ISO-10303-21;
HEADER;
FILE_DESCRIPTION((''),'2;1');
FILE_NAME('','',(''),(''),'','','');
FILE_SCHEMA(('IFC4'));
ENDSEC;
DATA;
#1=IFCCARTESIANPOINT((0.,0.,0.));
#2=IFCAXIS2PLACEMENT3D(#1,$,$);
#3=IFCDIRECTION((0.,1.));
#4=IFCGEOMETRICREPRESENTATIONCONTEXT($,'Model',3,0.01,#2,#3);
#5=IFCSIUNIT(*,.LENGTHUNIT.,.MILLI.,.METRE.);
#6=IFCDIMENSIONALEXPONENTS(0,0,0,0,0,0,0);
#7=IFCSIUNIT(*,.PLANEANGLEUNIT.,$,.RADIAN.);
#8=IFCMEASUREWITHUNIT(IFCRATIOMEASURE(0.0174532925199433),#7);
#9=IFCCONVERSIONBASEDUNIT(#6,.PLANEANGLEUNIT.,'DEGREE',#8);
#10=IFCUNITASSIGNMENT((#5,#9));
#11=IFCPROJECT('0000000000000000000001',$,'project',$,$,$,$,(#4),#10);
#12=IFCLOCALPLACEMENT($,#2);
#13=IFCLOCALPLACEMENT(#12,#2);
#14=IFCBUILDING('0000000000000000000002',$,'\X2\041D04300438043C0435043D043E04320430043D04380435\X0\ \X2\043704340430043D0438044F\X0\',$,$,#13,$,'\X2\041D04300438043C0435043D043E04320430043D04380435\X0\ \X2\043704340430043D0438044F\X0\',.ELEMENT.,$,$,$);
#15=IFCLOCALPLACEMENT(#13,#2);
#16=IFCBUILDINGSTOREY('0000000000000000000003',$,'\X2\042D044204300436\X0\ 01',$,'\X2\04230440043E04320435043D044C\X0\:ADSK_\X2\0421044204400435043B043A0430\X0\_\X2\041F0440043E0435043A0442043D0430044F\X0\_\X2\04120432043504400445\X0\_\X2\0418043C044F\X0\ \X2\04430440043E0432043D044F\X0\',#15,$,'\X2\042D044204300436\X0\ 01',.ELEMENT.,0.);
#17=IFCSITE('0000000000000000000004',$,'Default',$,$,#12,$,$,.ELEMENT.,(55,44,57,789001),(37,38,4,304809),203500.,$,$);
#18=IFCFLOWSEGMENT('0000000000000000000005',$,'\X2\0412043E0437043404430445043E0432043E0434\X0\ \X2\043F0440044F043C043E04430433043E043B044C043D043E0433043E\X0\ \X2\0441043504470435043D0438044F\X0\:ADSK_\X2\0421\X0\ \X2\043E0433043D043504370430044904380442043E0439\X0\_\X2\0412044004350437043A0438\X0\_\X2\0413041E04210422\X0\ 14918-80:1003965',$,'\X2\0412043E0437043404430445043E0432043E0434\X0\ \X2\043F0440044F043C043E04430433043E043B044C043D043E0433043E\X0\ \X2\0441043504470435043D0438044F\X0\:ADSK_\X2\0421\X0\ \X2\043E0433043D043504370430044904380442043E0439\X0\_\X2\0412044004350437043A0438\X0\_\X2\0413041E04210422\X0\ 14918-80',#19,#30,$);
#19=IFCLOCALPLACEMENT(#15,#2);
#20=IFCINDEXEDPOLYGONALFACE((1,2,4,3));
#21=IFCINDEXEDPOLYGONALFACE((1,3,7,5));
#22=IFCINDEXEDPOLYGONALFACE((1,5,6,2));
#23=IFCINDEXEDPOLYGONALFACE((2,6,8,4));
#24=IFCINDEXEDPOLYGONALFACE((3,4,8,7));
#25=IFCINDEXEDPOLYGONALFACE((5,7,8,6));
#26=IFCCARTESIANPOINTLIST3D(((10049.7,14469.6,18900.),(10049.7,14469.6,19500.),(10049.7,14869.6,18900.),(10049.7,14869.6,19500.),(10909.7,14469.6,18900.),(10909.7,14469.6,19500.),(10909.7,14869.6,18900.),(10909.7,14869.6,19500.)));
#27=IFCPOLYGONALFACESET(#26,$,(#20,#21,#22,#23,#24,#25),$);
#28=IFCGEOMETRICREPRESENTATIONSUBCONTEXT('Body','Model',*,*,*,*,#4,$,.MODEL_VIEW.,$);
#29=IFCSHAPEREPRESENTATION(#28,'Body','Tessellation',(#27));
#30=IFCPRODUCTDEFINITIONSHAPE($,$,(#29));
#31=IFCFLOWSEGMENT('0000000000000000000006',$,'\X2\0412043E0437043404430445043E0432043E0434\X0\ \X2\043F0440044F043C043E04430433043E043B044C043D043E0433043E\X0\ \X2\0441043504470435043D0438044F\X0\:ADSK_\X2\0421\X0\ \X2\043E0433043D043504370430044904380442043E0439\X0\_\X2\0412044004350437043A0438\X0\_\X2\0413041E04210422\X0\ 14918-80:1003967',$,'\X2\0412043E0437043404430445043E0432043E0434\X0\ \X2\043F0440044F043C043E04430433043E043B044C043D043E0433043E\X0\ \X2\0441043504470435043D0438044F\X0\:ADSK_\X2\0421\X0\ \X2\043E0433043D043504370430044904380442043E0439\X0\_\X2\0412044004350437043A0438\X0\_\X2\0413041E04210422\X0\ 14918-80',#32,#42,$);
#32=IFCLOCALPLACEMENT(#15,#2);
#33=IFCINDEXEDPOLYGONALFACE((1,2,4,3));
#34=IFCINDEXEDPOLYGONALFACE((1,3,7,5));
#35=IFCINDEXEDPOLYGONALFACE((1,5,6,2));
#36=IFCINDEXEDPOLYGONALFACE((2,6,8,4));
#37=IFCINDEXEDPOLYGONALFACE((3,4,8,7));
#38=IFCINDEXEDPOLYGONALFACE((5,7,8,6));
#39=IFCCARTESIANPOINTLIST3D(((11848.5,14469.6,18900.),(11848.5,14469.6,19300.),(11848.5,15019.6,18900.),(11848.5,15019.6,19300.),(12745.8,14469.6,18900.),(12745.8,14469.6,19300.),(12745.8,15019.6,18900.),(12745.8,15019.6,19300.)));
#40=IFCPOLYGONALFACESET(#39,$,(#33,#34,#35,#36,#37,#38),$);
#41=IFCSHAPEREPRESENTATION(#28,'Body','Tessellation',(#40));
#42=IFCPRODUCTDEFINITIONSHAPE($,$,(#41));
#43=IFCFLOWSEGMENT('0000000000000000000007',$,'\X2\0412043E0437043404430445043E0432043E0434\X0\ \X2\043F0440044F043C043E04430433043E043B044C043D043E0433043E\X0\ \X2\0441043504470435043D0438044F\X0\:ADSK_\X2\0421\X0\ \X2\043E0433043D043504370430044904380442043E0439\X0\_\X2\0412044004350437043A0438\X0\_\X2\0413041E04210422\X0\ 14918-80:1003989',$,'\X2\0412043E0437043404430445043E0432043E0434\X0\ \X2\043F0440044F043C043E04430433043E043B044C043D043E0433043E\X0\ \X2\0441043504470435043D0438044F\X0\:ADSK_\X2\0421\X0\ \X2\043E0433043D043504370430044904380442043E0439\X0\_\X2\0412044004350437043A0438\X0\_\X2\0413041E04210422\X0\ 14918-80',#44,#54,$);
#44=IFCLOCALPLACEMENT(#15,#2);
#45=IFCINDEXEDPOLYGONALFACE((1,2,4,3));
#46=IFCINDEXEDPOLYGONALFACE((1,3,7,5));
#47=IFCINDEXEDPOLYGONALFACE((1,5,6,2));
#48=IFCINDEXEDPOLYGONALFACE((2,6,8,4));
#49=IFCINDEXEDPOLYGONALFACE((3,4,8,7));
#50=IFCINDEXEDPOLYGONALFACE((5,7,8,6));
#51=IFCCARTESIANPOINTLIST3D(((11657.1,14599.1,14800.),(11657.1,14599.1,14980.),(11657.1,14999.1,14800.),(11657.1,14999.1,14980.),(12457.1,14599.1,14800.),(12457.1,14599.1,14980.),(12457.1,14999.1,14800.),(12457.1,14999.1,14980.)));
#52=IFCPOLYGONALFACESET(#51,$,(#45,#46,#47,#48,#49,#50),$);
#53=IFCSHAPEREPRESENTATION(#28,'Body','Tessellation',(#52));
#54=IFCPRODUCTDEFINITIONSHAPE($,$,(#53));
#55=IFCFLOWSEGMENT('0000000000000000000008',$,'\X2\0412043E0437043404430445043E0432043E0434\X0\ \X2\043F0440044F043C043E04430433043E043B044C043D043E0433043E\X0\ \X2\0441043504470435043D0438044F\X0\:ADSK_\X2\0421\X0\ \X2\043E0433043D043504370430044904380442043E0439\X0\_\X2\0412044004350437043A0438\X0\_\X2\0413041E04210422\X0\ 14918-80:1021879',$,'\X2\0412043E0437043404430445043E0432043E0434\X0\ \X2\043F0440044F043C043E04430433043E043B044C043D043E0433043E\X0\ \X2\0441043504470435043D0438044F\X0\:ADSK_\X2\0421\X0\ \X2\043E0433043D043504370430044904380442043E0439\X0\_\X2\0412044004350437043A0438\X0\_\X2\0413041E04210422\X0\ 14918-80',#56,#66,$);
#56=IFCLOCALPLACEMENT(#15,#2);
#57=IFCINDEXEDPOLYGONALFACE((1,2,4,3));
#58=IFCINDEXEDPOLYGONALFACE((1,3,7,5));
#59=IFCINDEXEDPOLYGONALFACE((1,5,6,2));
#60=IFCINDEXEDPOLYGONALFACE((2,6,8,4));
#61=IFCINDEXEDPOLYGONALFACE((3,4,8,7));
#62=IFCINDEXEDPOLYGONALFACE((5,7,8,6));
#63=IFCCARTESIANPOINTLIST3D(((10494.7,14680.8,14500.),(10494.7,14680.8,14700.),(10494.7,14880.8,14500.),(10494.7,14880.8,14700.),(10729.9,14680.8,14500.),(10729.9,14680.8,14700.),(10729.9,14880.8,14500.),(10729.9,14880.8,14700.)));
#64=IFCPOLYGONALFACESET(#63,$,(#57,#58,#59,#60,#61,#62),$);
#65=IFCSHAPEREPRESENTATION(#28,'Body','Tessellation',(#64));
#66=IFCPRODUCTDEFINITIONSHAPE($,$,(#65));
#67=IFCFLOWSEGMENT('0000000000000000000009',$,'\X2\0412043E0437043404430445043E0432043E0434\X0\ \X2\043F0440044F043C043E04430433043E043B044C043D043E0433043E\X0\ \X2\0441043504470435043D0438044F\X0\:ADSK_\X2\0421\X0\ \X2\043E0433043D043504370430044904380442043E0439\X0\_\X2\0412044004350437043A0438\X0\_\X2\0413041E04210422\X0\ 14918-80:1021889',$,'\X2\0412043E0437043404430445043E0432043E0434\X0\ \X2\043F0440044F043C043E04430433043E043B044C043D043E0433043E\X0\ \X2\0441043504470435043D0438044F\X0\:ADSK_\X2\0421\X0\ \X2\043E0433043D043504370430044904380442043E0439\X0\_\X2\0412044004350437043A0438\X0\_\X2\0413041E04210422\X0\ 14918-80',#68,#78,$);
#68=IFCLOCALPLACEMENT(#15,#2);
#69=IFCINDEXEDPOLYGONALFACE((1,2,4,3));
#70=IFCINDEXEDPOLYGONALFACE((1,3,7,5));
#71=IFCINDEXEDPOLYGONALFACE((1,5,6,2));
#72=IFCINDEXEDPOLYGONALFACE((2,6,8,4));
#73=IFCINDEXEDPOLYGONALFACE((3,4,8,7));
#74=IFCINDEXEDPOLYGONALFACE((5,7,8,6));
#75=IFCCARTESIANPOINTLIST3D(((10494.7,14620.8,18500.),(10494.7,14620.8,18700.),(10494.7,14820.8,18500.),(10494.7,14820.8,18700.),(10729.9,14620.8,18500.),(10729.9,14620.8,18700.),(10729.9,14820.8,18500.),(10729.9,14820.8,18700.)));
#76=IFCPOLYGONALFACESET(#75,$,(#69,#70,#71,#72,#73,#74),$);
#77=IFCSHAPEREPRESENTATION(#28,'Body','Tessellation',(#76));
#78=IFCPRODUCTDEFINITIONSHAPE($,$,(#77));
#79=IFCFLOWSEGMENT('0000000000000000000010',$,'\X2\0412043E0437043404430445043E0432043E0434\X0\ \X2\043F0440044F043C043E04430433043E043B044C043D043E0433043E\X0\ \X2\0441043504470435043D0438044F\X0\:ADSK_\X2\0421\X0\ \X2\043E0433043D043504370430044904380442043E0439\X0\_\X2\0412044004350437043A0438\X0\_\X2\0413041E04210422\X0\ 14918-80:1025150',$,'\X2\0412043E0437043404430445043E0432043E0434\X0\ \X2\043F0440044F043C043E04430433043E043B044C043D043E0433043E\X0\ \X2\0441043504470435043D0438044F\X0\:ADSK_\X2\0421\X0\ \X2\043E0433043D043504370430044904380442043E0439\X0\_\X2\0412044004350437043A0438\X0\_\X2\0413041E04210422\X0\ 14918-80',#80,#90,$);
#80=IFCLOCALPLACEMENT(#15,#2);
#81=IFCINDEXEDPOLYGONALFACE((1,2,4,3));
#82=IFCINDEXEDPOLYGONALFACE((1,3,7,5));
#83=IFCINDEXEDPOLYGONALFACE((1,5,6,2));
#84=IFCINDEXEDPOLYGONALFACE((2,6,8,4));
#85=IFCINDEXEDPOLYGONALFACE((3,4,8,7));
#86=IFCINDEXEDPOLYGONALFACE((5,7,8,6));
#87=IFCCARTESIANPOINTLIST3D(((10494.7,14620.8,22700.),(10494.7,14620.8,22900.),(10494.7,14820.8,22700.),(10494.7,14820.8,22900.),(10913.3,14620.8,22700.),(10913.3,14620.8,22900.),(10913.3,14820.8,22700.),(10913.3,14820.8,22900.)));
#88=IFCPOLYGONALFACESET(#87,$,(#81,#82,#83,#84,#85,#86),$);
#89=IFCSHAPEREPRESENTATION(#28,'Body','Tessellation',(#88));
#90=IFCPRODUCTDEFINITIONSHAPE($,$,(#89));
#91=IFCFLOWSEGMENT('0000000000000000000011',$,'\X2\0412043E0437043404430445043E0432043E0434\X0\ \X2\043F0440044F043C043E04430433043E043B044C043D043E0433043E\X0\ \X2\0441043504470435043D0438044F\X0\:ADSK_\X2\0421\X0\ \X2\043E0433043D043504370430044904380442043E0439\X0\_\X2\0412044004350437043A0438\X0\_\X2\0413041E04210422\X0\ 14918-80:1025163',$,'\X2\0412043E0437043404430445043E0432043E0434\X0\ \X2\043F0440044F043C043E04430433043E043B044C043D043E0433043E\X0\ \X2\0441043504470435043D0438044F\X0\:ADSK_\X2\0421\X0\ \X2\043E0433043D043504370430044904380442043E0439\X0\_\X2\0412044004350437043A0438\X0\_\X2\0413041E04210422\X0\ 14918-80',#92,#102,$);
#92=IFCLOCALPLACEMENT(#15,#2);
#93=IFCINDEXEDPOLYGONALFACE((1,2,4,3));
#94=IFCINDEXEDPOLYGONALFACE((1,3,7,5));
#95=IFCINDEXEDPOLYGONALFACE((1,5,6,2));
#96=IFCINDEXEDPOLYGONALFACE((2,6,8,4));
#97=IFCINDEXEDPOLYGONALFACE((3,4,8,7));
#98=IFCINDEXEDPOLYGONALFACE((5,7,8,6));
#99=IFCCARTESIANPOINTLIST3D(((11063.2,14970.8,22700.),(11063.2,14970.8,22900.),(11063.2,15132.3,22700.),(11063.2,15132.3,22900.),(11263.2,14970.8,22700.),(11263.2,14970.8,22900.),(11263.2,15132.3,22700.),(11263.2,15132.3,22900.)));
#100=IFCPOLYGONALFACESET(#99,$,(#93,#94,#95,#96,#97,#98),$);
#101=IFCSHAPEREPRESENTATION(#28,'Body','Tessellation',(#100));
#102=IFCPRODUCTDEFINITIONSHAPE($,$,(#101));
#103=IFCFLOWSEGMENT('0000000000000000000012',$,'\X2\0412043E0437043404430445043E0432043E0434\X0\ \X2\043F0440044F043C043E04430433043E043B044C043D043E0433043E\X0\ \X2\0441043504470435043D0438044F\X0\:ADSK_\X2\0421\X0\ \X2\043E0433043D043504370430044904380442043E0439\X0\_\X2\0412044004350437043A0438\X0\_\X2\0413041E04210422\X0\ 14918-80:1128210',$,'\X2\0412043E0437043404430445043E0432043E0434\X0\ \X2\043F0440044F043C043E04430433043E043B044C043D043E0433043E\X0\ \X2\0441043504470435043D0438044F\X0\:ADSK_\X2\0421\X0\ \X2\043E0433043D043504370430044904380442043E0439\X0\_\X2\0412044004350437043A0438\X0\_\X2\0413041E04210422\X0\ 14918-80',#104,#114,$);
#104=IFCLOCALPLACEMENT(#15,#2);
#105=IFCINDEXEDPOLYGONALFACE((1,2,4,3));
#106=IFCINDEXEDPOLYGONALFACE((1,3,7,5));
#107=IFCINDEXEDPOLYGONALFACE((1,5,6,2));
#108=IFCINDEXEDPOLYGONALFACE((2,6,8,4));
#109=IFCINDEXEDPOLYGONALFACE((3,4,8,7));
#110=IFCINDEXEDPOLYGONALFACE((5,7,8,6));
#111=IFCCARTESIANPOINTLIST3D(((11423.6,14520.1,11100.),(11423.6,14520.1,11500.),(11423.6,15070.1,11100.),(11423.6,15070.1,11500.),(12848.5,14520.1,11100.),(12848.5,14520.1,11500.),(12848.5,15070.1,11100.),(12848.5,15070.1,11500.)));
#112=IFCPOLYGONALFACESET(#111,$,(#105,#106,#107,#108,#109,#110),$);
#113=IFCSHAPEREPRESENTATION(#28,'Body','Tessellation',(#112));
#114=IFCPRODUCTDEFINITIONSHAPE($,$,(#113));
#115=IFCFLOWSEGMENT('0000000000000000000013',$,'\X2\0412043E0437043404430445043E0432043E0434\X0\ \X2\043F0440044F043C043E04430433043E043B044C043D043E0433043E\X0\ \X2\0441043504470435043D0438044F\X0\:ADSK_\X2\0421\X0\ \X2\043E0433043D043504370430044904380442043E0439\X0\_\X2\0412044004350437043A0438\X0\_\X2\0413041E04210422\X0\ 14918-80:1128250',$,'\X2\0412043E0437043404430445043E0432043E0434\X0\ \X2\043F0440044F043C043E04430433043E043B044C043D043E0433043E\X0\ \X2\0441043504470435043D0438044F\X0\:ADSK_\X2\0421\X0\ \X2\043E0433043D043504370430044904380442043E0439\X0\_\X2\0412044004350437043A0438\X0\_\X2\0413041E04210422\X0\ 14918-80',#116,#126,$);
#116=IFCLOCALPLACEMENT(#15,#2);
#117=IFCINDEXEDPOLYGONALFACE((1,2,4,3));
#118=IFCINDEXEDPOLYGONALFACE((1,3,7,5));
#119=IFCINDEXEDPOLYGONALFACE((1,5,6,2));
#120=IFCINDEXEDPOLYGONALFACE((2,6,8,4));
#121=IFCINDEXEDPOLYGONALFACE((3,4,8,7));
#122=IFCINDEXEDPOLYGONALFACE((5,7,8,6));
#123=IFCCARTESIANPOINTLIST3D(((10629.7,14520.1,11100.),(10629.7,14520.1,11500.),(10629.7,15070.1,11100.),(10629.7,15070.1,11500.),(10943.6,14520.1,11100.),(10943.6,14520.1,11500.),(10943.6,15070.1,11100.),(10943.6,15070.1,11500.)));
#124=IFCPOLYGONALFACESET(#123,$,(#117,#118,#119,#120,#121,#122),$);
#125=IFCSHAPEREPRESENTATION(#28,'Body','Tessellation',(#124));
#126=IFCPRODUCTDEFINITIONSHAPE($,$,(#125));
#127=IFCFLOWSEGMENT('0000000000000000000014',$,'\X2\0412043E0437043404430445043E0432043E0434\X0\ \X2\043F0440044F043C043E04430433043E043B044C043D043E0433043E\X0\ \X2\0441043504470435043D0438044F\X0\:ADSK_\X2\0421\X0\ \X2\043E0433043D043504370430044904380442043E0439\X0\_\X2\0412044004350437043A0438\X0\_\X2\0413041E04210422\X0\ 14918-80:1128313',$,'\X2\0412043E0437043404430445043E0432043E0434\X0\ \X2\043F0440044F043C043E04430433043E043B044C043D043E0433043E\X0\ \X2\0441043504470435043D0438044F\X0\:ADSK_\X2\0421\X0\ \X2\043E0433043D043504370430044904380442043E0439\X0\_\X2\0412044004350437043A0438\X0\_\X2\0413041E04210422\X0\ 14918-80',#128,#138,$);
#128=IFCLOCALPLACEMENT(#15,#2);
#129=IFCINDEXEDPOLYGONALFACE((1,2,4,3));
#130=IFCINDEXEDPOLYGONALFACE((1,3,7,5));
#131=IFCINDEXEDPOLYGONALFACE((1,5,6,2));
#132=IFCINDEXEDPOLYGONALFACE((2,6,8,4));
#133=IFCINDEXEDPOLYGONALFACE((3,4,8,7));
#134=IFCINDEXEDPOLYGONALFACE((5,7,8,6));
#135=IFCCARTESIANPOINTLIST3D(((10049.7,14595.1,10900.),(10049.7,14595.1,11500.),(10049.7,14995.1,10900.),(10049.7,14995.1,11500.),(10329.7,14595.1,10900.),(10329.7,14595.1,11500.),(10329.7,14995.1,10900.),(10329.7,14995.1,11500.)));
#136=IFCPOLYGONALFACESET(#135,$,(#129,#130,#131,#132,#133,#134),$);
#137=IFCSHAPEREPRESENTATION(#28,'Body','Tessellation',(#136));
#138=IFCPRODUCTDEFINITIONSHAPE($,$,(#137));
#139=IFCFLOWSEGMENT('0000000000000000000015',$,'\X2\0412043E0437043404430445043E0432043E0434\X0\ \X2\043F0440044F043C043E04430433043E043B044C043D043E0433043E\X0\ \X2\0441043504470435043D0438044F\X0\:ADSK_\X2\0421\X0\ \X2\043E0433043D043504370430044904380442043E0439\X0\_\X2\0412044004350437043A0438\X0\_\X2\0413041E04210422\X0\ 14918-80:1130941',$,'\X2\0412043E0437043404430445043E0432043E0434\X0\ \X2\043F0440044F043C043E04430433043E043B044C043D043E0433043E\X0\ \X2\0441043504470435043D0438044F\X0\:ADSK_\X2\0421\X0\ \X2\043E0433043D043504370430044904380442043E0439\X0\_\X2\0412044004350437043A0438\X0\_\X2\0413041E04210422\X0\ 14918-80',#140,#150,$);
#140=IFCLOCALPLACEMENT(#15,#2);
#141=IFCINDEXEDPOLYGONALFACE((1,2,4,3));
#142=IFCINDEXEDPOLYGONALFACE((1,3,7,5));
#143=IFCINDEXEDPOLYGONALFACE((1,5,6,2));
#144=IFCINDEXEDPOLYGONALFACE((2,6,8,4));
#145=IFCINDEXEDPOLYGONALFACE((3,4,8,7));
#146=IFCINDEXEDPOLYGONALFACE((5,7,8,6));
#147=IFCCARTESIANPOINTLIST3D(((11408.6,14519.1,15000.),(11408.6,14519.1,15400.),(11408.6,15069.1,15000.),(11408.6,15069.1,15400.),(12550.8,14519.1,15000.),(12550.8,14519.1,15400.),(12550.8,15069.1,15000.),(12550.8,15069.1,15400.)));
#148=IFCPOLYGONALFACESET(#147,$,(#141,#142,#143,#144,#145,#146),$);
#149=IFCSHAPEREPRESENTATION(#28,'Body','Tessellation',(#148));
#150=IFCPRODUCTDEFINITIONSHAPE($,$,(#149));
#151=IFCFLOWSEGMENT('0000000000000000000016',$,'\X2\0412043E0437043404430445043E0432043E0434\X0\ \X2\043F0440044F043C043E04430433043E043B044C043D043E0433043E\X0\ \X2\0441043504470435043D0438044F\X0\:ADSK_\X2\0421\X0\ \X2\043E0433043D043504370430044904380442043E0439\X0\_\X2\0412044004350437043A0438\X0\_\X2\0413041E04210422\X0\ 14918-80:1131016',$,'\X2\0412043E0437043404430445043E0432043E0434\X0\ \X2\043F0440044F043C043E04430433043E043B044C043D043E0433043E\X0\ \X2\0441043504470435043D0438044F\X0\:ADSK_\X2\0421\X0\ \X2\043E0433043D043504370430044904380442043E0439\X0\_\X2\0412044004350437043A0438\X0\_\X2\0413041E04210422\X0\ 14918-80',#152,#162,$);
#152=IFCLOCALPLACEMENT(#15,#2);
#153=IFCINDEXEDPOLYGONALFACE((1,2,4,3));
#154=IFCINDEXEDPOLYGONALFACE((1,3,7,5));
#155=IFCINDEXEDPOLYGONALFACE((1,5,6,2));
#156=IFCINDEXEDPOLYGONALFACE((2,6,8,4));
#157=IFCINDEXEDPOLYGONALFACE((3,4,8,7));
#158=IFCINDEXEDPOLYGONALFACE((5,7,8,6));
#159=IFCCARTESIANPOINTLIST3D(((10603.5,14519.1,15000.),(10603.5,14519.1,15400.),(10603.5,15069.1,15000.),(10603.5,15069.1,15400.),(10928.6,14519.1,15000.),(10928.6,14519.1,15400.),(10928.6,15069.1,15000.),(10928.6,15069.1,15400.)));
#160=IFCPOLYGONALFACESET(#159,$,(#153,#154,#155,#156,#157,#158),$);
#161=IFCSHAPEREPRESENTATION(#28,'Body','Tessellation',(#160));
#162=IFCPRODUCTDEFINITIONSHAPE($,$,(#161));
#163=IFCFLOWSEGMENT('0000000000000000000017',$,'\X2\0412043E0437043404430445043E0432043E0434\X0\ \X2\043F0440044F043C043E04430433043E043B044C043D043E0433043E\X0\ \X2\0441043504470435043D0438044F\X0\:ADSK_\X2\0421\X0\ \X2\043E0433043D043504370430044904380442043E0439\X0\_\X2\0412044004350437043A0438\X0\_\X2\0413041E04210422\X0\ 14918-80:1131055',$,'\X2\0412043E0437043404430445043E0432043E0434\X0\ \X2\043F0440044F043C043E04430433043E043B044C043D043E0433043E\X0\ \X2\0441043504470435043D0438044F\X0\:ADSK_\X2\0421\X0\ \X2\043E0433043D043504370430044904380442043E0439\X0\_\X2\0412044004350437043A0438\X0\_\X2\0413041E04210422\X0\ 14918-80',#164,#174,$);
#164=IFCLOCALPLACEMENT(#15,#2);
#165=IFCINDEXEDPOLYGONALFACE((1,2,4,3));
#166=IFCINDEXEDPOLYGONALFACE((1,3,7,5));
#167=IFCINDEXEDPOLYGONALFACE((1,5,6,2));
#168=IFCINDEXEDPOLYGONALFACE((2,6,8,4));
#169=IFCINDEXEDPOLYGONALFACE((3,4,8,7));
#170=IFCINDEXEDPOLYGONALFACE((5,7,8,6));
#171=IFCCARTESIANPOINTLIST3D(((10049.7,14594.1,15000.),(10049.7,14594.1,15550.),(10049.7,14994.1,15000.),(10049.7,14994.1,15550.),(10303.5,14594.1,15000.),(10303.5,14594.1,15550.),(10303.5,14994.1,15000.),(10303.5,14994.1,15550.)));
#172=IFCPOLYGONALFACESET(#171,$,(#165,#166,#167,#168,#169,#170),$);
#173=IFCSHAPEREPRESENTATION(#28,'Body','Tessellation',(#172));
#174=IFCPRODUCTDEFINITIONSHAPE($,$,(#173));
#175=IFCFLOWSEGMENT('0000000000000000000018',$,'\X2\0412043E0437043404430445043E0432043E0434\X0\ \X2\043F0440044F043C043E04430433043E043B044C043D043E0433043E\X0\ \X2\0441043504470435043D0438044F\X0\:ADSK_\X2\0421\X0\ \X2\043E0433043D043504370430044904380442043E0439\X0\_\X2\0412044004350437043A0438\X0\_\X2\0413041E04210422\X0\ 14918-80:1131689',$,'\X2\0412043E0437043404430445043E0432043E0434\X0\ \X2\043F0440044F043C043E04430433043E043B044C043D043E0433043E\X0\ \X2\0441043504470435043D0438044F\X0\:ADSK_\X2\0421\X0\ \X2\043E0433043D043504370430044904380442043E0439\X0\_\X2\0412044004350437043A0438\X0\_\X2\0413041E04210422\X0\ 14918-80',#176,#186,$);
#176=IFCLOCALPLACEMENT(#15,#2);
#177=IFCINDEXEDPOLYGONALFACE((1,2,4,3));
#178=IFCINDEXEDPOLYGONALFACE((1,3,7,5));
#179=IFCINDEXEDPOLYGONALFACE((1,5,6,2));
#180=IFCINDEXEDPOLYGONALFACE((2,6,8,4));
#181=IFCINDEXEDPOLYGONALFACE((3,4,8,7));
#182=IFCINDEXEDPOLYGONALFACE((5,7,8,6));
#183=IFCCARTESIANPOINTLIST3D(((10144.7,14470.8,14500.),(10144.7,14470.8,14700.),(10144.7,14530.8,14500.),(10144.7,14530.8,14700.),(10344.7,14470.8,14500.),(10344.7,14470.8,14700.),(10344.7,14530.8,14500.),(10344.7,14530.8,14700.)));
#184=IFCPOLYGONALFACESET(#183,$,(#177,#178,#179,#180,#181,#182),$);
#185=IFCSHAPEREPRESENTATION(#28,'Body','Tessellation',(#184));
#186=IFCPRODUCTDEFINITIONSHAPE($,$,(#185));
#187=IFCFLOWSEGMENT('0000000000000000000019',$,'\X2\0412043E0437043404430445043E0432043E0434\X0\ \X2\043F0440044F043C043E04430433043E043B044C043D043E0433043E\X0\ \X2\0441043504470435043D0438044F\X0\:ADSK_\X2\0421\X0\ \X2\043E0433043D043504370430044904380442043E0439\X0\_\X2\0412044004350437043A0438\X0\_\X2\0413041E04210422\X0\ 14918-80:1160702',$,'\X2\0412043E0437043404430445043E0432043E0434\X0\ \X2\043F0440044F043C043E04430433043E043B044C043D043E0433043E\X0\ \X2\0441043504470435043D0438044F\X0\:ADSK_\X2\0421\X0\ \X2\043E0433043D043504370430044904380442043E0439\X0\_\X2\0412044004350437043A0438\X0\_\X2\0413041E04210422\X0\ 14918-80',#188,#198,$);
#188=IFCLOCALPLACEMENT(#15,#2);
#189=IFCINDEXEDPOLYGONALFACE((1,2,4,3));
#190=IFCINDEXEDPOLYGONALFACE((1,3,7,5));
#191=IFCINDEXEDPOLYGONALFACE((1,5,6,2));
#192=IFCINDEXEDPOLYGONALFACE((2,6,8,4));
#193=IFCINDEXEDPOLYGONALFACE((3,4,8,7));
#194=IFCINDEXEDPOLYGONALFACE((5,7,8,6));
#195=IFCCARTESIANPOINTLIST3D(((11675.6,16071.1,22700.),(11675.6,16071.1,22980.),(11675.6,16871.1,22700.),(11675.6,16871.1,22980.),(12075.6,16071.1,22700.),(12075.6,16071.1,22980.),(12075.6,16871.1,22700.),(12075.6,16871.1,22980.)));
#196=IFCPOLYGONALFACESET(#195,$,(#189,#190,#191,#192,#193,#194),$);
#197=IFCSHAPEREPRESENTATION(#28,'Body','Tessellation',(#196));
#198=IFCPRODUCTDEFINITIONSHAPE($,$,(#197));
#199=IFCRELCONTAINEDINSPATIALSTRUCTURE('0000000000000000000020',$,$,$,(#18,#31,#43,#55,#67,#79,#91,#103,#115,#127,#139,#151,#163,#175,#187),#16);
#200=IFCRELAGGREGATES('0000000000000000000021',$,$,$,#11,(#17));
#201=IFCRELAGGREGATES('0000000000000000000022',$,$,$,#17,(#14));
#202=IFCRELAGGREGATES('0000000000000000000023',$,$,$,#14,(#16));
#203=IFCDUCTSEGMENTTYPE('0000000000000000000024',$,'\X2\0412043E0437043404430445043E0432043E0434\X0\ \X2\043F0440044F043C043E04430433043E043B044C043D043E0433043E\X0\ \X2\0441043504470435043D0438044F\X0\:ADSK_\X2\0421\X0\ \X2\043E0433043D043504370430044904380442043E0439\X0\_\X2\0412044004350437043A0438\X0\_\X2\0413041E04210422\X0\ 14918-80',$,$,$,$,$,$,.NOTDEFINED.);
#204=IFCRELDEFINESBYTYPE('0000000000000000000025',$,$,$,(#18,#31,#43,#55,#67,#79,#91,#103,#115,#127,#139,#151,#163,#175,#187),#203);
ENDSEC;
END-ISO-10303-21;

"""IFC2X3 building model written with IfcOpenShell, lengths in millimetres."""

from ifc_helpers import new_model, entity, si_unit, converted_unit, direction, frame, origin, origin_2d_with_axis, place, context, subcontext, project, spatial, rectangle, extrude, type_object, element, save


model = new_model("IFC2X3")

# Units and contexts
model_context = context("Model", 3, precision=0.01, world=origin(), true_north=direction((0.0, 1.0)))
body_context = subcontext(model_context, "Body", "Model", "MODEL_VIEW")
ifc_project = project(units=[si_unit("LENGTHUNIT", "METRE", prefix="MILLI"), converted_unit("PLANEANGLEUNIT", "DEGREE", entity("IfcRatioMeasure", 0.0174532925199433), si_unit("PLANEANGLEUNIT", "RADIAN"), dimensions=[0, 0, 0, 0, 0, 0, 0])], contexts=[model_context])

# Site, building, storey
site_placement = place(None, origin())
site = spatial("IfcSite", under=ifc_project, at=site_placement, Name="Default", CompositionType="ELEMENT", RefLatitude=(55, 44, 57, 789001), RefLongitude=(37, 38, 4, 304809), RefElevation=203500.0)
building_placement = place(site_placement, origin())
building = spatial("IfcBuilding", under=site, at=building_placement, Name="Наименование здания", LongName="Наименование здания", CompositionType="ELEMENT")
storey_placement = place(building_placement, origin())
storey = spatial("IfcBuildingStorey", under=building, at=storey_placement, Name="Этаж 01", ObjectType="Уровень:ADSK_Стрелка_Проектная_Вверх_Имя уровня", LongName="Этаж 01", CompositionType="ELEMENT", Elevation=0.0)

# Flow segments
duct_segment_type_1 = type_object("IfcDuctSegmentType", Name="Воздуховод прямоугольного сечения:ADSK_С огнезащитой_Врезки_ГОСТ 14918-80", PredefinedType="NOTDEFINED")
flow_segment_1_placement = place(storey_placement, frame((10049.7, 14469.6, 18900.0)))
element("IfcFlowSegment", 1, at=flow_segment_1_placement, inside=storey, type_object=duct_segment_type_1, Name="Воздуховод прямоугольного сечения:ADSK_С огнезащитой_Врезки_ГОСТ 14918-80:1003965", ObjectType="Воздуховод прямоугольного сечения:ADSK_С огнезащитой_Врезки_ГОСТ 14918-80", context=body_context, shape_type="SweptSolid", body=[
    extrude(rectangle(XDim=860.0, YDim=400.0, at=origin_2d_with_axis()), frame((430.0, 200.0, 0.0)), (0.0, 0.0, 1.0), 600.0),
])
flow_segment_2_placement = place(storey_placement, frame((11848.5, 14469.6, 18900.0)))
element("IfcFlowSegment", 2, at=flow_segment_2_placement, inside=storey, type_object=duct_segment_type_1, Name="Воздуховод прямоугольного сечения:ADSK_С огнезащитой_Врезки_ГОСТ 14918-80:1003967", ObjectType="Воздуховод прямоугольного сечения:ADSK_С огнезащитой_Врезки_ГОСТ 14918-80", context=body_context, shape_type="SweptSolid", body=[
    extrude(rectangle(XDim=897.3, YDim=550.0, at=origin_2d_with_axis()), frame((448.6, 275.0, 0.0)), (0.0, 0.0, 1.0), 400.0),
])
flow_segment_3_placement = place(storey_placement, frame((11657.1, 14599.1, 14800.0)))
element("IfcFlowSegment", 3, at=flow_segment_3_placement, inside=storey, type_object=duct_segment_type_1, Name="Воздуховод прямоугольного сечения:ADSK_С огнезащитой_Врезки_ГОСТ 14918-80:1003989", ObjectType="Воздуховод прямоугольного сечения:ADSK_С огнезащитой_Врезки_ГОСТ 14918-80", context=body_context, shape_type="SweptSolid", body=[
    extrude(rectangle(XDim=400.0, YDim=800.0, at=origin_2d_with_axis()), frame((400.0, 200.0, 0.0), z_axis=(0.0, 0.0, 1.0), x_axis=(0.0, 1.0, 0.0)), (0.0, 0.0, 1.0), 180.0),
])
flow_segment_4_placement = place(storey_placement, frame((10494.7, 14680.8, 14500.0)))
element("IfcFlowSegment", 4, at=flow_segment_4_placement, inside=storey, type_object=duct_segment_type_1, Name="Воздуховод прямоугольного сечения:ADSK_С огнезащитой_Врезки_ГОСТ 14918-80:1021879", ObjectType="Воздуховод прямоугольного сечения:ADSK_С огнезащитой_Врезки_ГОСТ 14918-80", context=body_context, shape_type="SweptSolid", body=[
    extrude(rectangle(XDim=235.2, YDim=200.0, at=origin_2d_with_axis()), frame((117.6, 100.0, 0.0), z_axis=(0.0, 0.0, 1.0), x_axis=(-1.0, 0.0, 0.0)), (0.0, 0.0, 1.0), 200.0),
])
flow_segment_5_placement = place(storey_placement, frame((10494.7, 14620.8, 18500.0)))
element("IfcFlowSegment", 5, at=flow_segment_5_placement, inside=storey, type_object=duct_segment_type_1, Name="Воздуховод прямоугольного сечения:ADSK_С огнезащитой_Врезки_ГОСТ 14918-80:1021889", ObjectType="Воздуховод прямоугольного сечения:ADSK_С огнезащитой_Врезки_ГОСТ 14918-80", context=body_context, shape_type="SweptSolid", body=[
    extrude(rectangle(XDim=235.2, YDim=200.0, at=origin_2d_with_axis()), frame((117.6, 100.0, 0.0), z_axis=(0.0, 0.0, 1.0), x_axis=(-1.0, 0.0, 0.0)), (0.0, 0.0, 1.0), 200.0),
])
flow_segment_6_placement = place(storey_placement, frame((10494.7, 14620.8, 22700.0)))
element("IfcFlowSegment", 6, at=flow_segment_6_placement, inside=storey, type_object=duct_segment_type_1, Name="Воздуховод прямоугольного сечения:ADSK_С огнезащитой_Врезки_ГОСТ 14918-80:1025150", ObjectType="Воздуховод прямоугольного сечения:ADSK_С огнезащитой_Врезки_ГОСТ 14918-80", context=body_context, shape_type="SweptSolid", body=[
    extrude(rectangle(XDim=418.5, YDim=200.0, at=origin_2d_with_axis()), frame((209.3, 100.0, 0.0)), (0.0, 0.0, 1.0), 200.0),
])
flow_segment_7_placement = place(storey_placement, frame((11063.2, 14970.8, 22700.0)))
element("IfcFlowSegment", 7, at=flow_segment_7_placement, inside=storey, type_object=duct_segment_type_1, Name="Воздуховод прямоугольного сечения:ADSK_С огнезащитой_Врезки_ГОСТ 14918-80:1025163", ObjectType="Воздуховод прямоугольного сечения:ADSK_С огнезащитой_Врезки_ГОСТ 14918-80", context=body_context, shape_type="SweptSolid", body=[
    extrude(rectangle(XDim=161.5, YDim=200.0, at=origin_2d_with_axis()), frame((100.0, 80.7, 0.0), z_axis=(0.0, 0.0, 1.0), x_axis=(0.0, -1.0, 0.0)), (0.0, 0.0, 1.0), 200.0),
])
flow_segment_8_placement = place(storey_placement, frame((11423.6, 14520.1, 11100.0)))
element("IfcFlowSegment", 8, at=flow_segment_8_placement, inside=storey, type_object=duct_segment_type_1, Name="Воздуховод прямоугольного сечения:ADSK_С огнезащитой_Врезки_ГОСТ 14918-80:1128210", ObjectType="Воздуховод прямоугольного сечения:ADSK_С огнезащитой_Врезки_ГОСТ 14918-80", context=body_context, shape_type="SweptSolid", body=[
    extrude(rectangle(XDim=1424.9, YDim=550.0, at=origin_2d_with_axis()), frame((712.4, 275.0, 0.0)), (0.0, 0.0, 1.0), 400.0),
])
flow_segment_9_placement = place(storey_placement, frame((10629.7, 14520.1, 11100.0)))
element("IfcFlowSegment", 9, at=flow_segment_9_placement, inside=storey, type_object=duct_segment_type_1, Name="Воздуховод прямоугольного сечения:ADSK_С огнезащитой_Врезки_ГОСТ 14918-80:1128250", ObjectType="Воздуховод прямоугольного сечения:ADSK_С огнезащитой_Врезки_ГОСТ 14918-80", context=body_context, shape_type="SweptSolid", body=[
    extrude(rectangle(XDim=313.9, YDim=550.0, at=origin_2d_with_axis()), frame((156.9, 275.0, 0.0), z_axis=(0.0, 0.0, 1.0), x_axis=(-1.0, 0.0, 0.0)), (0.0, 0.0, 1.0), 400.0),
])
flow_segment_10_placement = place(storey_placement, frame((10049.7, 14595.1, 10900.0)))
element("IfcFlowSegment", 10, at=flow_segment_10_placement, inside=storey, type_object=duct_segment_type_1, Name="Воздуховод прямоугольного сечения:ADSK_С огнезащитой_Врезки_ГОСТ 14918-80:1128313", ObjectType="Воздуховод прямоугольного сечения:ADSK_С огнезащитой_Врезки_ГОСТ 14918-80", context=body_context, shape_type="SweptSolid", body=[
    extrude(rectangle(XDim=280.0, YDim=400.0, at=origin_2d_with_axis()), frame((140.0, 200.0, 0.0), z_axis=(0.0, 0.0, 1.0), x_axis=(-1.0, 0.0, 0.0)), (0.0, 0.0, 1.0), 600.0),
])
flow_segment_11_placement = place(storey_placement, frame((11408.6, 14519.1, 15000.0)))
element("IfcFlowSegment", 11, at=flow_segment_11_placement, inside=storey, type_object=duct_segment_type_1, Name="Воздуховод прямоугольного сечения:ADSK_С огнезащитой_Врезки_ГОСТ 14918-80:1130941", ObjectType="Воздуховод прямоугольного сечения:ADSK_С огнезащитой_Врезки_ГОСТ 14918-80", context=body_context, shape_type="SweptSolid", body=[
    extrude(rectangle(XDim=1142.1, YDim=550.0, at=origin_2d_with_axis()), frame((571.1, 275.0, 0.0), z_axis=(0.0, 0.0, 1.0), x_axis=(-1.0, 0.0, 0.0)), (0.0, 0.0, 1.0), 400.0),
])
flow_segment_12_placement = place(storey_placement, frame((10603.5, 14519.1, 15000.0)))
element("IfcFlowSegment", 12, at=flow_segment_12_placement, inside=storey, type_object=duct_segment_type_1, Name="Воздуховод прямоугольного сечения:ADSK_С огнезащитой_Врезки_ГОСТ 14918-80:1131016", ObjectType="Воздуховод прямоугольного сечения:ADSK_С огнезащитой_Врезки_ГОСТ 14918-80", context=body_context, shape_type="SweptSolid", body=[
    extrude(rectangle(XDim=325.1, YDim=550.0, at=origin_2d_with_axis()), frame((162.6, 275.0, 0.0), z_axis=(0.0, 0.0, 1.0), x_axis=(-1.0, 0.0, 0.0)), (0.0, 0.0, 1.0), 400.0),
])
flow_segment_13_placement = place(storey_placement, frame((10049.7, 14594.1, 15000.0)))
element("IfcFlowSegment", 13, at=flow_segment_13_placement, inside=storey, type_object=duct_segment_type_1, Name="Воздуховод прямоугольного сечения:ADSK_С огнезащитой_Врезки_ГОСТ 14918-80:1131055", ObjectType="Воздуховод прямоугольного сечения:ADSK_С огнезащитой_Врезки_ГОСТ 14918-80", context=body_context, shape_type="SweptSolid", body=[
    extrude(rectangle(XDim=253.8, YDim=400.0, at=origin_2d_with_axis()), frame((126.9, 200.0, 0.0), z_axis=(0.0, 0.0, 1.0), x_axis=(-1.0, 0.0, 0.0)), (0.0, 0.0, 1.0), 550.0),
])
flow_segment_14_placement = place(storey_placement, frame((10144.7, 14470.8, 14500.0)))
element("IfcFlowSegment", 14, at=flow_segment_14_placement, inside=storey, type_object=duct_segment_type_1, Name="Воздуховод прямоугольного сечения:ADSK_С огнезащитой_Врезки_ГОСТ 14918-80:1131689", ObjectType="Воздуховод прямоугольного сечения:ADSK_С огнезащитой_Врезки_ГОСТ 14918-80", context=body_context, shape_type="SweptSolid", body=[
    extrude(rectangle(XDim=60.0, YDim=200.0, at=origin_2d_with_axis()), frame((100.0, 30.0, 0.0), z_axis=(0.0, 0.0, 1.0), x_axis=(0.0, 1.0, 0.0)), (0.0, 0.0, 1.0), 200.0),
])
flow_segment_15_placement = place(storey_placement, frame((11675.6, 16071.1, 22700.0)))
element("IfcFlowSegment", 15, at=flow_segment_15_placement, inside=storey, type_object=duct_segment_type_1, Name="Воздуховод прямоугольного сечения:ADSK_С огнезащитой_Врезки_ГОСТ 14918-80:1160702", ObjectType="Воздуховод прямоугольного сечения:ADSK_С огнезащитой_Врезки_ГОСТ 14918-80", context=body_context, shape_type="SweptSolid", body=[
    extrude(rectangle(XDim=400.0, YDim=800.0, at=origin_2d_with_axis()), frame((200.0, 400.0, 0.0)), (0.0, 0.0, 1.0), 280.0),
])

save(model, "model.ifc")
